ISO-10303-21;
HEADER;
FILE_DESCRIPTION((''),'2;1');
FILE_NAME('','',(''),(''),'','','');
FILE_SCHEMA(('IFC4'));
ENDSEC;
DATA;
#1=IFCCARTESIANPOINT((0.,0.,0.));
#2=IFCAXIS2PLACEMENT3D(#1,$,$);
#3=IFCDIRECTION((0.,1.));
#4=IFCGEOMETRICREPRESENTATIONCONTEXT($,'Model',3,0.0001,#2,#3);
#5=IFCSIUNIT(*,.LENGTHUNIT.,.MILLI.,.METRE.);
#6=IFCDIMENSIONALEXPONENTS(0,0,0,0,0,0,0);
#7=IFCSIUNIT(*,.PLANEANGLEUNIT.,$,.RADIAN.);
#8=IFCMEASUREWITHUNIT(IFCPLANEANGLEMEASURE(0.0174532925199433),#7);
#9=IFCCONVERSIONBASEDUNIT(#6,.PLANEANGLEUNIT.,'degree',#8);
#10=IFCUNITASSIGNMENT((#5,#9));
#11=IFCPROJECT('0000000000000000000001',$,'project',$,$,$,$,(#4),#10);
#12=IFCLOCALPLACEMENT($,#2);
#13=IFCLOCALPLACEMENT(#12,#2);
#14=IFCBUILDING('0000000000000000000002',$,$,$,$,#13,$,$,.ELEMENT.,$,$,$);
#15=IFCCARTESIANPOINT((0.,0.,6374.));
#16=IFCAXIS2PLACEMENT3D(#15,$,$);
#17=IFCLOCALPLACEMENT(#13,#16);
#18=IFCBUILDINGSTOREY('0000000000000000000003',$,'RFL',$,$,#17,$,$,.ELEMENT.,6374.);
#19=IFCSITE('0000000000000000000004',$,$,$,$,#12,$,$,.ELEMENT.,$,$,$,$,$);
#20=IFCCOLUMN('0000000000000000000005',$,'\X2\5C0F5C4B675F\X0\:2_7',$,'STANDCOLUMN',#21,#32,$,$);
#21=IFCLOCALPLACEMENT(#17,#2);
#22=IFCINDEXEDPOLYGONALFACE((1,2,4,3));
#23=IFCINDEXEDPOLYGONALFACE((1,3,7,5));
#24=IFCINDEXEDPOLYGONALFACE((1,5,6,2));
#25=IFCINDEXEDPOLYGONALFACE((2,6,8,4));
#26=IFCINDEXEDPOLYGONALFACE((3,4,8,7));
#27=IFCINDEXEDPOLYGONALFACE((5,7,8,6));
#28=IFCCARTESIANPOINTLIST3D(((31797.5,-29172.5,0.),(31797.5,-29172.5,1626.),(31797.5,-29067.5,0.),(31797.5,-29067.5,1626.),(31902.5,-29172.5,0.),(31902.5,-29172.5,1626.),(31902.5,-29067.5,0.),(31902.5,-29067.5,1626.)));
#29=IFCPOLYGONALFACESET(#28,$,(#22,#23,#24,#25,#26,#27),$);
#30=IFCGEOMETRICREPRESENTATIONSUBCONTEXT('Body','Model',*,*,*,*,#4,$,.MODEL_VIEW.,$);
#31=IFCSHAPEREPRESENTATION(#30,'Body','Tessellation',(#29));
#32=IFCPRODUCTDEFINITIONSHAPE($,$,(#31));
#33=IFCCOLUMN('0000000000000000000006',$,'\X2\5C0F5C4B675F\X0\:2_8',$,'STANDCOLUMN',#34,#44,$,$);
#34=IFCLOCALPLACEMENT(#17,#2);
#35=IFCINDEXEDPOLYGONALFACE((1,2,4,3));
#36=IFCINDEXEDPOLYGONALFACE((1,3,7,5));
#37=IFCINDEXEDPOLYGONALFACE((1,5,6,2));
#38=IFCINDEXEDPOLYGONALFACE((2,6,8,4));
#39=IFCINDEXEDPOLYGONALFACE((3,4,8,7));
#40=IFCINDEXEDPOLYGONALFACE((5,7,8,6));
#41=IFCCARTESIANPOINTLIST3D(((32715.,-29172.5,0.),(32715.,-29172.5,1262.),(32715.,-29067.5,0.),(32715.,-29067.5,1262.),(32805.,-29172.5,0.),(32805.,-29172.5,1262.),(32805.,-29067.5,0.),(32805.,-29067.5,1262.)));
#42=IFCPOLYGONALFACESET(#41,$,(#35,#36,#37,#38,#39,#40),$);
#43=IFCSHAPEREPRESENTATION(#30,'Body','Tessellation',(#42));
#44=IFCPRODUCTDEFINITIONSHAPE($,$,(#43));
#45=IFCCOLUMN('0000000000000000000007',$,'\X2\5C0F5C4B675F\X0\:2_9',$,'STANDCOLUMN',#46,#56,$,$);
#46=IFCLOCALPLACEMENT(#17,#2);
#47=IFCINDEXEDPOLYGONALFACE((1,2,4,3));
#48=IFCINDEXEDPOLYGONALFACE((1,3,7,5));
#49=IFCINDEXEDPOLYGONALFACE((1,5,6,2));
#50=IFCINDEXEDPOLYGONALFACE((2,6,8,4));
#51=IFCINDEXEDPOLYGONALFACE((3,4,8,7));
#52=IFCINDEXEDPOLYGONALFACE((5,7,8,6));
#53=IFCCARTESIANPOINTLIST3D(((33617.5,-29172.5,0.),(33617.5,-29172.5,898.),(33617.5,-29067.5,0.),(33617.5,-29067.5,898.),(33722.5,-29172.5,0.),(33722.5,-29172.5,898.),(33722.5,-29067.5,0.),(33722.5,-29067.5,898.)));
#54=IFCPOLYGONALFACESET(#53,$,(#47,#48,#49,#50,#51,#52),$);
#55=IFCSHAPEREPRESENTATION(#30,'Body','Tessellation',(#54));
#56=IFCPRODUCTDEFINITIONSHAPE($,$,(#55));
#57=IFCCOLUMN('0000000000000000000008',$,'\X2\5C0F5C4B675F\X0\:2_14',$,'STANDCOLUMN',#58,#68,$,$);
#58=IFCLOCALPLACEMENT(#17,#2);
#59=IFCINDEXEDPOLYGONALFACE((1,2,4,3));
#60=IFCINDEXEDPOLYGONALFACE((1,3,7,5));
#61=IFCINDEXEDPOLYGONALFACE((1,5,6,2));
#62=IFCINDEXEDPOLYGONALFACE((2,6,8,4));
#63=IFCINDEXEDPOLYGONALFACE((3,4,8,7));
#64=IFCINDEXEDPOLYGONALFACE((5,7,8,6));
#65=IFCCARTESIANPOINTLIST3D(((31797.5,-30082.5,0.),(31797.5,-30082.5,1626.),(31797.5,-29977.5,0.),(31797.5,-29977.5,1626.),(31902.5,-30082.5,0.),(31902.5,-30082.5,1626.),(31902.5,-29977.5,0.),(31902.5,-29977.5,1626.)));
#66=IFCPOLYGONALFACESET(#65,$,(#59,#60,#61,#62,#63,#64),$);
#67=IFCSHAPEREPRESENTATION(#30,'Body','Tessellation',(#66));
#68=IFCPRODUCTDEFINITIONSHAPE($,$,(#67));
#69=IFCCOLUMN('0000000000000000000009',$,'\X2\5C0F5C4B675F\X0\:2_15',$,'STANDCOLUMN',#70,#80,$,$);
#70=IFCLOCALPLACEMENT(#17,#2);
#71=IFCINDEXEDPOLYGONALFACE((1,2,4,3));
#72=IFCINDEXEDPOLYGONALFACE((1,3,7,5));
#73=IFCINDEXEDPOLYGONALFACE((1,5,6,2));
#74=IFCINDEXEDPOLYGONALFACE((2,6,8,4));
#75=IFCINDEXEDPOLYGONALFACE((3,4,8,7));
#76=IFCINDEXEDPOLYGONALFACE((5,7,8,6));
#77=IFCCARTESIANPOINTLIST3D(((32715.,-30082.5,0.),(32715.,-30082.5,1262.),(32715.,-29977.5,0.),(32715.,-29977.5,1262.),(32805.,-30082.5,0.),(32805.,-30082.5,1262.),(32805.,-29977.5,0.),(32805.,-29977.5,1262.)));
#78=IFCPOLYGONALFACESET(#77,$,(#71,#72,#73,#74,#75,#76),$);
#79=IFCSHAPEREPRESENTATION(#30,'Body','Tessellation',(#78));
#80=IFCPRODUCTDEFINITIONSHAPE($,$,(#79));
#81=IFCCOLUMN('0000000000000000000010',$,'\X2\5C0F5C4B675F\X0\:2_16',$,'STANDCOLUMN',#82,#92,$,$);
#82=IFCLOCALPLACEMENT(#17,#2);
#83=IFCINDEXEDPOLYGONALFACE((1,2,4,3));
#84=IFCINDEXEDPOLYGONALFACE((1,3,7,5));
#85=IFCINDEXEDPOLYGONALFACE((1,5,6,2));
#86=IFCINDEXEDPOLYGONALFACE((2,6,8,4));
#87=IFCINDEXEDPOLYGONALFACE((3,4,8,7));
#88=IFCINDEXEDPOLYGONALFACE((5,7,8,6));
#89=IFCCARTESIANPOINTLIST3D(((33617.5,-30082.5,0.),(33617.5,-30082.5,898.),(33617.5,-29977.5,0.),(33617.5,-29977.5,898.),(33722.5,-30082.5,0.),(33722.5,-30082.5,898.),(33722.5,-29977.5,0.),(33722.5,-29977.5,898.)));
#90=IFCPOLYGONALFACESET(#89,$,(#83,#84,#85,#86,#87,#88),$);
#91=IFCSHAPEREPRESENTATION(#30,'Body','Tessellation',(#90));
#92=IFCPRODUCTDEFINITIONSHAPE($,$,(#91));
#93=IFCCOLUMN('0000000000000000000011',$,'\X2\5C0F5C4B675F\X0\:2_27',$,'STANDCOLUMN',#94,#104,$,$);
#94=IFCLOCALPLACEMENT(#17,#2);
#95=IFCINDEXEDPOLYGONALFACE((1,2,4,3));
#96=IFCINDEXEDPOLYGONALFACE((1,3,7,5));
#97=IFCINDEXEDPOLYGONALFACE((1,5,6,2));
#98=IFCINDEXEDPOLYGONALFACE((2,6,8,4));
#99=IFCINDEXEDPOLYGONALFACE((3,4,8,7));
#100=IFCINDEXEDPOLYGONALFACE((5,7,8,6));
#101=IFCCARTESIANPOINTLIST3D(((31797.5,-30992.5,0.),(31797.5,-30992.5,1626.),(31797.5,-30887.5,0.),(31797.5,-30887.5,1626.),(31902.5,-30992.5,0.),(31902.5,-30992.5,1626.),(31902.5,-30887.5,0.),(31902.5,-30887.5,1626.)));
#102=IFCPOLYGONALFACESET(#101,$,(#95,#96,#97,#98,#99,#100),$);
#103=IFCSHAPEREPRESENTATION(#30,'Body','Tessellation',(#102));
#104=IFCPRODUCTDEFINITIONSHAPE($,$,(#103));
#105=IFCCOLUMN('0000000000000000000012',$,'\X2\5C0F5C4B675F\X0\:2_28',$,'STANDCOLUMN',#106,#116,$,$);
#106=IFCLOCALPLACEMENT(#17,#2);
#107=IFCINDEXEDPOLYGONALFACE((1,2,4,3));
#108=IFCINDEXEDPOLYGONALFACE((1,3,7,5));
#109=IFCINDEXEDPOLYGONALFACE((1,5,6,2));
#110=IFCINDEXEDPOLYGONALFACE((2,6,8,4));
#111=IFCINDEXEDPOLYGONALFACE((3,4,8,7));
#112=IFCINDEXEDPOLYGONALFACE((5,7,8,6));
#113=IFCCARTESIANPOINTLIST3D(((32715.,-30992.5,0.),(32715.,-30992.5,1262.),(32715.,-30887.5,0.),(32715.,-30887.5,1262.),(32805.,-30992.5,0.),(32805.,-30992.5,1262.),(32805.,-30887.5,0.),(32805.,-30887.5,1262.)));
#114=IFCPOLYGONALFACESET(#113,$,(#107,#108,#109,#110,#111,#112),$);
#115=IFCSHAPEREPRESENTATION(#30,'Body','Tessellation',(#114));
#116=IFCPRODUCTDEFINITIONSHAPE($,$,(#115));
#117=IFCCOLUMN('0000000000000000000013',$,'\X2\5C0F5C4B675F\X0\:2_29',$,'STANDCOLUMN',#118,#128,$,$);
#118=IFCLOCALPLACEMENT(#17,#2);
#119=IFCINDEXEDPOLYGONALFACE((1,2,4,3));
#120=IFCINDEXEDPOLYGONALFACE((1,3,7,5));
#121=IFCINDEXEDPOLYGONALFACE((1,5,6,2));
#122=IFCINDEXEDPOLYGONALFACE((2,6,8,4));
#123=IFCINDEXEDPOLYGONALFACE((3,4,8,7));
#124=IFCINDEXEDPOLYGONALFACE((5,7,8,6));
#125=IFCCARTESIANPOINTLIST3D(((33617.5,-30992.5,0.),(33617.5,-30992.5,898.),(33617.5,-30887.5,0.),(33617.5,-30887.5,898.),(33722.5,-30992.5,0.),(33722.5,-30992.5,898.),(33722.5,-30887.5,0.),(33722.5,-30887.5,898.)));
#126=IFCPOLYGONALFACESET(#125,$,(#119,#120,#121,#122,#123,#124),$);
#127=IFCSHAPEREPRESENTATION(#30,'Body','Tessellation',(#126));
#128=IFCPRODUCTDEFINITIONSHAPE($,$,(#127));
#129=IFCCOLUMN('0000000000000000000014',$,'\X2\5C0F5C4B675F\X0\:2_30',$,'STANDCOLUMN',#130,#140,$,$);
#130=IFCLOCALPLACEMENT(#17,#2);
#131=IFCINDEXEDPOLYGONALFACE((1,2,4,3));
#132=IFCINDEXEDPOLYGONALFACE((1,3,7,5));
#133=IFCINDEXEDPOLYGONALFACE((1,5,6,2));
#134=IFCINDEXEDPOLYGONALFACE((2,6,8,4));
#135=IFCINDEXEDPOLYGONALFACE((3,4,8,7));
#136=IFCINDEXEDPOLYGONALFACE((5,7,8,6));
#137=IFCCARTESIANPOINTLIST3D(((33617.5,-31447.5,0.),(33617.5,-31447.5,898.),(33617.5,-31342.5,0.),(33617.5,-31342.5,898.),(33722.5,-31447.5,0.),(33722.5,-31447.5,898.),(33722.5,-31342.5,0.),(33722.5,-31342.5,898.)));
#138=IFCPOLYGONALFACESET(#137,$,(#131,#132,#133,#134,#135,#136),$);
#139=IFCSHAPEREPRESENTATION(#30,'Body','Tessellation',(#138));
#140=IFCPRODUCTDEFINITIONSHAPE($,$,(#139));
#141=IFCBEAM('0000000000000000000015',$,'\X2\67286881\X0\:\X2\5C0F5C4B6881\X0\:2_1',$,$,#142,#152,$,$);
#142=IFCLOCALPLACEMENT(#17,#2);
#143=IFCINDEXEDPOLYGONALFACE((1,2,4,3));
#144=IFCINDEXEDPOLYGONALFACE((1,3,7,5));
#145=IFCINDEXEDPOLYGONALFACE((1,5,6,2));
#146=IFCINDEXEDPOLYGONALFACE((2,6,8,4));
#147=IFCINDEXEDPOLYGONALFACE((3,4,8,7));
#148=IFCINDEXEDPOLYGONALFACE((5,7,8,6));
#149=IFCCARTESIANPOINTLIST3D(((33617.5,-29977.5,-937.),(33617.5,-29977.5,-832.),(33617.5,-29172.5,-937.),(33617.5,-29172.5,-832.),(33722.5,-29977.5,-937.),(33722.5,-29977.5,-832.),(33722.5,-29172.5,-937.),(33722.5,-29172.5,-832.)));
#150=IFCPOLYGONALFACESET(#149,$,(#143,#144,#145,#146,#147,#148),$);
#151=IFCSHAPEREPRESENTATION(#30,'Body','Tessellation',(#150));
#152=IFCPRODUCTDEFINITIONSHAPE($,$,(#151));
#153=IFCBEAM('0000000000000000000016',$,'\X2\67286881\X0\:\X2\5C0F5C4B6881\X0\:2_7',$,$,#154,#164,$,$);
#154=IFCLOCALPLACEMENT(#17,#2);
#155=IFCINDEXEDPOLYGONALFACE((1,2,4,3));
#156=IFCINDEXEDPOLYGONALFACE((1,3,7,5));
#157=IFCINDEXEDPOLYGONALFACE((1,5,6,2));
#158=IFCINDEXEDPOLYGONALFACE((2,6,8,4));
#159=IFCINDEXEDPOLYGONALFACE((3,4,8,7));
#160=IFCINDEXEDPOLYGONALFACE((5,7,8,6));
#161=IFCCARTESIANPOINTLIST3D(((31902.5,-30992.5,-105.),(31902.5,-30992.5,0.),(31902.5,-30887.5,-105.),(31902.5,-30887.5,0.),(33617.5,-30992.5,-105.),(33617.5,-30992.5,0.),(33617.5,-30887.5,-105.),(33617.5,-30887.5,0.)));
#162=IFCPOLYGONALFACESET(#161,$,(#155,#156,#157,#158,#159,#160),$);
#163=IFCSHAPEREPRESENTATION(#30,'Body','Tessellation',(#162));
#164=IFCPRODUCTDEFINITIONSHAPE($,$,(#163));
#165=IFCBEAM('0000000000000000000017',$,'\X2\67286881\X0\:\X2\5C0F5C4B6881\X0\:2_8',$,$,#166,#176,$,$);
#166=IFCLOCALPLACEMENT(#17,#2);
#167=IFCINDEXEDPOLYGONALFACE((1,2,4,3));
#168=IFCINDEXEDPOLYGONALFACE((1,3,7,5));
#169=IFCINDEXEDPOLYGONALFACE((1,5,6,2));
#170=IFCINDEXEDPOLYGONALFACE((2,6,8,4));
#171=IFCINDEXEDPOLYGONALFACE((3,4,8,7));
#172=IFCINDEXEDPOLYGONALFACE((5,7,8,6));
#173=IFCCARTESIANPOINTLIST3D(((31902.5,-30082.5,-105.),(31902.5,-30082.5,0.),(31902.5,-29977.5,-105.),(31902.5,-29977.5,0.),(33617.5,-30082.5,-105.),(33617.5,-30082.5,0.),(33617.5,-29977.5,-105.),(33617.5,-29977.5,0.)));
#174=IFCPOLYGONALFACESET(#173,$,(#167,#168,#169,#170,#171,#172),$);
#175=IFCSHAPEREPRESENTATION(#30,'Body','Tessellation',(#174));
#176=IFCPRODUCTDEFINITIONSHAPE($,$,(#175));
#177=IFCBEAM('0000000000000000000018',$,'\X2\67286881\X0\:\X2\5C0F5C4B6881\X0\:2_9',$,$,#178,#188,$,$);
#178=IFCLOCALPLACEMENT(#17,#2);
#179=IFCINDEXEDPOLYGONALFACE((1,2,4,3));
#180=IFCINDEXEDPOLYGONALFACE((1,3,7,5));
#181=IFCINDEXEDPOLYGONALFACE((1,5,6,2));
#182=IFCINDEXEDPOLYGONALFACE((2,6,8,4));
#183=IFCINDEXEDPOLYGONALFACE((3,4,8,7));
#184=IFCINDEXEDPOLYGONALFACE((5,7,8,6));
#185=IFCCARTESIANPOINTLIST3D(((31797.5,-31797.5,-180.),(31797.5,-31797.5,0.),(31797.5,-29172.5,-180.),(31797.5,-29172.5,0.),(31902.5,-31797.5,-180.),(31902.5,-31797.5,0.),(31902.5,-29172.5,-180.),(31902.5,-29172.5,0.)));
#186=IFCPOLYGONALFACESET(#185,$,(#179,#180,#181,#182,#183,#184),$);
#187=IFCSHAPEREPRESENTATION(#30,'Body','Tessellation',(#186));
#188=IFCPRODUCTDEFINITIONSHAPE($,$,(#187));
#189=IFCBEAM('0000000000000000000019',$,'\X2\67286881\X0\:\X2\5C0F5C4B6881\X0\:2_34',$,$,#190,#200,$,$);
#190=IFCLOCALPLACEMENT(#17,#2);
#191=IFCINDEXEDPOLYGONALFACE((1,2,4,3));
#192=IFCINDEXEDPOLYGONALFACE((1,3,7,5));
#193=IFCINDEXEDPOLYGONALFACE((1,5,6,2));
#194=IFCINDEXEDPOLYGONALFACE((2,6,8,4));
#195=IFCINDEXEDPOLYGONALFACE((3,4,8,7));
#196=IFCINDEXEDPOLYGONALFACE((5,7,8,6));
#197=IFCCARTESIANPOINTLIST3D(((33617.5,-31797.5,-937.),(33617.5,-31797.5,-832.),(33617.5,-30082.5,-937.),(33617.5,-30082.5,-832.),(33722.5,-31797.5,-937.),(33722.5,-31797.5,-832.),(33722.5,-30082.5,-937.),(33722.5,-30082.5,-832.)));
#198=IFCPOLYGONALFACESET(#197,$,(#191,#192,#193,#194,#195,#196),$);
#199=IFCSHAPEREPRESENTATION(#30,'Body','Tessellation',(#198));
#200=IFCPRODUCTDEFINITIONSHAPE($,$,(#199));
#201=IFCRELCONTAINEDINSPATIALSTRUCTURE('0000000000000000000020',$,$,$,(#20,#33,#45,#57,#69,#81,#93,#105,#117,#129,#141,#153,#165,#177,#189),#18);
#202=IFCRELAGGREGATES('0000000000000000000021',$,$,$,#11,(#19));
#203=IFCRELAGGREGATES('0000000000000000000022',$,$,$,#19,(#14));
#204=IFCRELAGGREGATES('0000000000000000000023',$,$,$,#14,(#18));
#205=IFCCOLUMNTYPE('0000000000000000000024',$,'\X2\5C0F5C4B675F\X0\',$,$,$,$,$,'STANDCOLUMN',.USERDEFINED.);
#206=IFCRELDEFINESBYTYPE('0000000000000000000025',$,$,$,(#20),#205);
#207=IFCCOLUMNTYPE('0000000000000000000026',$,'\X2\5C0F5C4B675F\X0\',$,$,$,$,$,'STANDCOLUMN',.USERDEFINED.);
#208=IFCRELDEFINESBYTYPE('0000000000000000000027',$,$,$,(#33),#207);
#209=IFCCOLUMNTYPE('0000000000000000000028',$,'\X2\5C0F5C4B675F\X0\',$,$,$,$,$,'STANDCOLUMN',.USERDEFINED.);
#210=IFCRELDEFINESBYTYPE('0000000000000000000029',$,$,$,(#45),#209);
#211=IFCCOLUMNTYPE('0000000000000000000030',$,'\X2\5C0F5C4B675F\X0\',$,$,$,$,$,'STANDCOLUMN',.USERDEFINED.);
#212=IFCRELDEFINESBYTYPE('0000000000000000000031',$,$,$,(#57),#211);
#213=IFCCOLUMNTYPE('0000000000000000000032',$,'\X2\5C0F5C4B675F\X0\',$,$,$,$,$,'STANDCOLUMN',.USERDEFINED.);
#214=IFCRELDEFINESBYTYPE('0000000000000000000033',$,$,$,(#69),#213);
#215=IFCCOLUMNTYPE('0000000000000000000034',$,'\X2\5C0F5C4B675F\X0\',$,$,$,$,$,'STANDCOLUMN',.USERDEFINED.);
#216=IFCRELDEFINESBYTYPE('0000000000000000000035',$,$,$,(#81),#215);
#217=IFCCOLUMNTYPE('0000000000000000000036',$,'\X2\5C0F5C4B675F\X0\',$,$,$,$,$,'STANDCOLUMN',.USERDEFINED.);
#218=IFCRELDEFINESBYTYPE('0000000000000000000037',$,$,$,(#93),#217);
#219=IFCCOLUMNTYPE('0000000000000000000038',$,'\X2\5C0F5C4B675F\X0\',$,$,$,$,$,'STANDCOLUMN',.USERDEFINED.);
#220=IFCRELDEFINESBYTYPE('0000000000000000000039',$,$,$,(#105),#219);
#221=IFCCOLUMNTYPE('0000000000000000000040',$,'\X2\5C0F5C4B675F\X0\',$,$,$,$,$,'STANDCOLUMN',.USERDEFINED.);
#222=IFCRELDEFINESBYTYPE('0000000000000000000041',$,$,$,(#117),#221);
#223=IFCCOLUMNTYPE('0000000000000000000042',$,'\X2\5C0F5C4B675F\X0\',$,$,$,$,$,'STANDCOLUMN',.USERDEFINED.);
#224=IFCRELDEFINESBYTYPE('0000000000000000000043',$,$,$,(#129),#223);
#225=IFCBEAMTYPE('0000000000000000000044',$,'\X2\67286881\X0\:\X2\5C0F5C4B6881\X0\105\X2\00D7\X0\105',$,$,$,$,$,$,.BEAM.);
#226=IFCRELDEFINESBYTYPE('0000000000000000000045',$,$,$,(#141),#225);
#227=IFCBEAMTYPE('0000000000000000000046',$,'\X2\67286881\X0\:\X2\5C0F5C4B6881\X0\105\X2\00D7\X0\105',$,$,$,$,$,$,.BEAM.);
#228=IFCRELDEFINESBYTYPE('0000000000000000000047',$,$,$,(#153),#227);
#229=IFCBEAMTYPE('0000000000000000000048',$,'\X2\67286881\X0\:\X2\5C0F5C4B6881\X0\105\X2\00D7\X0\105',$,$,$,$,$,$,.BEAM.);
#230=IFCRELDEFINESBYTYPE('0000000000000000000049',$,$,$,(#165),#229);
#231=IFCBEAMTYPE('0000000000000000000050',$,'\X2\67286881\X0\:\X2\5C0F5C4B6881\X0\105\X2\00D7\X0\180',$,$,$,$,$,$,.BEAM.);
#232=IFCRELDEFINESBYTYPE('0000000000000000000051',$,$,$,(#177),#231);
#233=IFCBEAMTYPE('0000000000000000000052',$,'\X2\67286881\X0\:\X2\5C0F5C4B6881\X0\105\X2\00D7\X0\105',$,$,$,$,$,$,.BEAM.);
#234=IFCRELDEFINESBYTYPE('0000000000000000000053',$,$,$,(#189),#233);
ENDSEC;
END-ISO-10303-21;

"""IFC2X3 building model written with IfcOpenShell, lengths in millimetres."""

from ifc_helpers import new_model, entity, si_unit, converted_unit, direction, frame, origin, origin_with_axes, origin_2d, place, context, subcontext, project, spatial, rectangle, extrude, type_object, element, save


model = new_model("IFC2X3")

# Units and contexts
model_context = context("Model", 3, precision=0.0001, world=origin(), true_north=direction((0.0, 1.0)))
body_context = subcontext(model_context, "Body", "Model", "MODEL_VIEW")
ifc_project = project(units=[si_unit("LENGTHUNIT", "METRE", prefix="MILLI"), converted_unit("PLANEANGLEUNIT", "degree", entity("IfcPlaneAngleMeasure", 0.0174532925199433), si_unit("PLANEANGLEUNIT", "RADIAN"), dimensions=[0, 0, 0, 0, 0, 0, 0])], contexts=[model_context])

# Site, building, storey
site_placement = place(None, origin())
site = spatial("IfcSite", under=ifc_project, at=site_placement, CompositionType="ELEMENT")
building_placement = place(site_placement, origin())
building = spatial("IfcBuilding", under=site, at=building_placement, CompositionType="ELEMENT")
storey_placement = place(building_placement, frame((0.0, 0.0, 6374.0)))
storey = spatial("IfcBuildingStorey", under=building, at=storey_placement, Name="RFL", CompositionType="ELEMENT", Elevation=6374.0)

# Columns
column_type_1 = type_object("IfcColumnType", Name="小屋束", ElementType="STANDCOLUMN", PredefinedType="USERDEFINED")
column_1_placement = place(storey_placement, frame((31850.0, -29120.0, 0.0)))
element("IfcColumn", 1, at=column_1_placement, inside=storey, type_object=column_type_1, Name="小屋束:2_7", ObjectType="STANDCOLUMN", context=body_context, shape_type="SweptSolid", body=[
    extrude(rectangle(XDim=105.0, YDim=105.0, at=origin_2d()), origin_with_axes(), (0.0, 0.0, 1.0), 1626.0),
])
column_type_2 = type_object("IfcColumnType", Name="小屋束", ElementType="STANDCOLUMN", PredefinedType="USERDEFINED")
column_2_placement = place(storey_placement, frame((32760.0, -29120.0, 0.0)))
element("IfcColumn", 2, at=column_2_placement, inside=storey, type_object=column_type_2, Name="小屋束:2_8", ObjectType="STANDCOLUMN", context=body_context, shape_type="SweptSolid", body=[
    extrude(rectangle(XDim=90.0, YDim=105.0, at=origin_2d()), origin_with_axes(), (0.0, 0.0, 1.0), 1262.0),
])
column_type_3 = type_object("IfcColumnType", Name="小屋束", ElementType="STANDCOLUMN", PredefinedType="USERDEFINED")
column_3_placement = place(storey_placement, frame((33670.0, -29120.0, 0.0)))
element("IfcColumn", 3, at=column_3_placement, inside=storey, type_object=column_type_3, Name="小屋束:2_9", ObjectType="STANDCOLUMN", context=body_context, shape_type="SweptSolid", body=[
    extrude(rectangle(XDim=105.0, YDim=105.0, at=origin_2d()), origin_with_axes(), (0.0, 0.0, 1.0), 898.0),
])
column_type_4 = type_object("IfcColumnType", Name="小屋束", ElementType="STANDCOLUMN", PredefinedType="USERDEFINED")
column_4_placement = place(storey_placement, frame((31850.0, -30030.0, 0.0)))
element("IfcColumn", 4, at=column_4_placement, inside=storey, type_object=column_type_4, Name="小屋束:2_14", ObjectType="STANDCOLUMN", context=body_context, shape_type="SweptSolid", body=[
    extrude(rectangle(XDim=105.0, YDim=105.0, at=origin_2d()), origin_with_axes(), (0.0, 0.0, 1.0), 1626.0),
])
column_type_5 = type_object("IfcColumnType", Name="小屋束", ElementType="STANDCOLUMN", PredefinedType="USERDEFINED")
column_5_placement = place(storey_placement, frame((32760.0, -30030.0, 0.0)))
element("IfcColumn", 5, at=column_5_placement, inside=storey, type_object=column_type_5, Name="小屋束:2_15", ObjectType="STANDCOLUMN", context=body_context, shape_type="SweptSolid", body=[
    extrude(rectangle(XDim=90.0, YDim=105.0, at=origin_2d()), origin_with_axes(), (0.0, 0.0, 1.0), 1262.0),
])
column_type_6 = type_object("IfcColumnType", Name="小屋束", ElementType="STANDCOLUMN", PredefinedType="USERDEFINED")
column_6_placement = place(storey_placement, frame((33670.0, -30030.0, 0.0)))
element("IfcColumn", 6, at=column_6_placement, inside=storey, type_object=column_type_6, Name="小屋束:2_16", ObjectType="STANDCOLUMN", context=body_context, shape_type="SweptSolid", body=[
    extrude(rectangle(XDim=105.0, YDim=105.0, at=origin_2d()), origin_with_axes(), (0.0, 0.0, 1.0), 898.0),
])
column_type_7 = type_object("IfcColumnType", Name="小屋束", ElementType="STANDCOLUMN", PredefinedType="USERDEFINED")
column_7_placement = place(storey_placement, frame((31850.0, -30940.0, 0.0)))
element("IfcColumn", 7, at=column_7_placement, inside=storey, type_object=column_type_7, Name="小屋束:2_27", ObjectType="STANDCOLUMN", context=body_context, shape_type="SweptSolid", body=[
    extrude(rectangle(XDim=105.0, YDim=105.0, at=origin_2d()), origin_with_axes(), (0.0, 0.0, 1.0), 1626.0),
])
column_type_8 = type_object("IfcColumnType", Name="小屋束", ElementType="STANDCOLUMN", PredefinedType="USERDEFINED")
column_8_placement = place(storey_placement, frame((32760.0, -30940.0, 0.0)))
element("IfcColumn", 8, at=column_8_placement, inside=storey, type_object=column_type_8, Name="小屋束:2_28", ObjectType="STANDCOLUMN", context=body_context, shape_type="SweptSolid", body=[
    extrude(rectangle(XDim=90.0, YDim=105.0, at=origin_2d()), origin_with_axes(), (0.0, 0.0, 1.0), 1262.0),
])
column_type_9 = type_object("IfcColumnType", Name="小屋束", ElementType="STANDCOLUMN", PredefinedType="USERDEFINED")
column_9_placement = place(storey_placement, frame((33670.0, -30940.0, 0.0)))
element("IfcColumn", 9, at=column_9_placement, inside=storey, type_object=column_type_9, Name="小屋束:2_29", ObjectType="STANDCOLUMN", context=body_context, shape_type="SweptSolid", body=[
    extrude(rectangle(XDim=105.0, YDim=105.0, at=origin_2d()), origin_with_axes(), (0.0, 0.0, 1.0), 898.0),
])
column_type_10 = type_object("IfcColumnType", Name="小屋束", ElementType="STANDCOLUMN", PredefinedType="USERDEFINED")
column_10_placement = place(storey_placement, frame((33670.0, -31395.0, 0.0)))
element("IfcColumn", 10, at=column_10_placement, inside=storey, type_object=column_type_10, Name="小屋束:2_30", ObjectType="STANDCOLUMN", context=body_context, shape_type="SweptSolid", body=[
    extrude(rectangle(XDim=105.0, YDim=105.0, at=origin_2d()), origin_with_axes(), (0.0, 0.0, 1.0), 898.0),
])

# Beams
beam_type_1 = type_object("IfcBeamType", Name="木梁:小屋梁105×105", PredefinedType="BEAM")
beam_1_placement = place(storey_placement, frame((33670.0, -29172.5, -884.5), z_axis=(0.0, -1.0, 0.0), x_axis=(1.0, 0.0, 0.0)))
element("IfcBeam", 11, at=beam_1_placement, inside=storey, type_object=beam_type_1, Name="木梁:小屋梁:2_1", context=body_context, shape_type="SweptSolid", body=[
    extrude(rectangle(XDim=105.0, YDim=105.0, at=origin_2d()), origin_with_axes(), (0.0, 0.0, 1.0), 805.0),
])
beam_type_2 = type_object("IfcBeamType", Name="木梁:小屋梁105×105", PredefinedType="BEAM")
beam_2_placement = place(storey_placement, frame((31902.5, -30940.0, -52.5), z_axis=(1.0, 0.0, 0.0), x_axis=(0.0, 1.0, 0.0)))
element("IfcBeam", 12, at=beam_2_placement, inside=storey, type_object=beam_type_2, Name="木梁:小屋梁:2_7", context=body_context, shape_type="SweptSolid", body=[
    extrude(rectangle(XDim=105.0, YDim=105.0, at=origin_2d()), origin_with_axes(), (0.0, 0.0, 1.0), 1715.0),
])
beam_type_3 = type_object("IfcBeamType", Name="木梁:小屋梁105×105", PredefinedType="BEAM")
beam_3_placement = place(storey_placement, frame((31902.5, -30030.0, -52.5), z_axis=(1.0, 0.0, 0.0), x_axis=(0.0, 1.0, 0.0)))
element("IfcBeam", 13, at=beam_3_placement, inside=storey, type_object=beam_type_3, Name="木梁:小屋梁:2_8", context=body_context, shape_type="SweptSolid", body=[
    extrude(rectangle(XDim=105.0, YDim=105.0, at=origin_2d()), origin_with_axes(), (0.0, 0.0, 1.0), 1715.0),
])
beam_type_4 = type_object("IfcBeamType", Name="木梁:小屋梁105×180", PredefinedType="BEAM")
beam_4_placement = place(storey_placement, frame((31850.0, -29172.5, -90.0), z_axis=(0.0, -1.0, 0.0), x_axis=(1.0, 0.0, 0.0)))
element("IfcBeam", 14, at=beam_4_placement, inside=storey, type_object=beam_type_4, Name="木梁:小屋梁:2_9", context=body_context, shape_type="SweptSolid", body=[
    extrude(rectangle(XDim=105.0, YDim=180.0, at=origin_2d()), origin_with_axes(), (0.0, 0.0, 1.0), 2625.0),
])
beam_type_5 = type_object("IfcBeamType", Name="木梁:小屋梁105×105", PredefinedType="BEAM")
beam_5_placement = place(storey_placement, frame((33670.0, -30082.5, -884.5), z_axis=(0.0, -1.0, 0.0), x_axis=(1.0, 0.0, 0.0)))
element("IfcBeam", 15, at=beam_5_placement, inside=storey, type_object=beam_type_5, Name="木梁:小屋梁:2_34", context=body_context, shape_type="SweptSolid", body=[
    extrude(rectangle(XDim=105.0, YDim=105.0, at=origin_2d()), origin_with_axes(), (0.0, 0.0, 1.0), 1715.0),
])

save(model, "model.ifc")
